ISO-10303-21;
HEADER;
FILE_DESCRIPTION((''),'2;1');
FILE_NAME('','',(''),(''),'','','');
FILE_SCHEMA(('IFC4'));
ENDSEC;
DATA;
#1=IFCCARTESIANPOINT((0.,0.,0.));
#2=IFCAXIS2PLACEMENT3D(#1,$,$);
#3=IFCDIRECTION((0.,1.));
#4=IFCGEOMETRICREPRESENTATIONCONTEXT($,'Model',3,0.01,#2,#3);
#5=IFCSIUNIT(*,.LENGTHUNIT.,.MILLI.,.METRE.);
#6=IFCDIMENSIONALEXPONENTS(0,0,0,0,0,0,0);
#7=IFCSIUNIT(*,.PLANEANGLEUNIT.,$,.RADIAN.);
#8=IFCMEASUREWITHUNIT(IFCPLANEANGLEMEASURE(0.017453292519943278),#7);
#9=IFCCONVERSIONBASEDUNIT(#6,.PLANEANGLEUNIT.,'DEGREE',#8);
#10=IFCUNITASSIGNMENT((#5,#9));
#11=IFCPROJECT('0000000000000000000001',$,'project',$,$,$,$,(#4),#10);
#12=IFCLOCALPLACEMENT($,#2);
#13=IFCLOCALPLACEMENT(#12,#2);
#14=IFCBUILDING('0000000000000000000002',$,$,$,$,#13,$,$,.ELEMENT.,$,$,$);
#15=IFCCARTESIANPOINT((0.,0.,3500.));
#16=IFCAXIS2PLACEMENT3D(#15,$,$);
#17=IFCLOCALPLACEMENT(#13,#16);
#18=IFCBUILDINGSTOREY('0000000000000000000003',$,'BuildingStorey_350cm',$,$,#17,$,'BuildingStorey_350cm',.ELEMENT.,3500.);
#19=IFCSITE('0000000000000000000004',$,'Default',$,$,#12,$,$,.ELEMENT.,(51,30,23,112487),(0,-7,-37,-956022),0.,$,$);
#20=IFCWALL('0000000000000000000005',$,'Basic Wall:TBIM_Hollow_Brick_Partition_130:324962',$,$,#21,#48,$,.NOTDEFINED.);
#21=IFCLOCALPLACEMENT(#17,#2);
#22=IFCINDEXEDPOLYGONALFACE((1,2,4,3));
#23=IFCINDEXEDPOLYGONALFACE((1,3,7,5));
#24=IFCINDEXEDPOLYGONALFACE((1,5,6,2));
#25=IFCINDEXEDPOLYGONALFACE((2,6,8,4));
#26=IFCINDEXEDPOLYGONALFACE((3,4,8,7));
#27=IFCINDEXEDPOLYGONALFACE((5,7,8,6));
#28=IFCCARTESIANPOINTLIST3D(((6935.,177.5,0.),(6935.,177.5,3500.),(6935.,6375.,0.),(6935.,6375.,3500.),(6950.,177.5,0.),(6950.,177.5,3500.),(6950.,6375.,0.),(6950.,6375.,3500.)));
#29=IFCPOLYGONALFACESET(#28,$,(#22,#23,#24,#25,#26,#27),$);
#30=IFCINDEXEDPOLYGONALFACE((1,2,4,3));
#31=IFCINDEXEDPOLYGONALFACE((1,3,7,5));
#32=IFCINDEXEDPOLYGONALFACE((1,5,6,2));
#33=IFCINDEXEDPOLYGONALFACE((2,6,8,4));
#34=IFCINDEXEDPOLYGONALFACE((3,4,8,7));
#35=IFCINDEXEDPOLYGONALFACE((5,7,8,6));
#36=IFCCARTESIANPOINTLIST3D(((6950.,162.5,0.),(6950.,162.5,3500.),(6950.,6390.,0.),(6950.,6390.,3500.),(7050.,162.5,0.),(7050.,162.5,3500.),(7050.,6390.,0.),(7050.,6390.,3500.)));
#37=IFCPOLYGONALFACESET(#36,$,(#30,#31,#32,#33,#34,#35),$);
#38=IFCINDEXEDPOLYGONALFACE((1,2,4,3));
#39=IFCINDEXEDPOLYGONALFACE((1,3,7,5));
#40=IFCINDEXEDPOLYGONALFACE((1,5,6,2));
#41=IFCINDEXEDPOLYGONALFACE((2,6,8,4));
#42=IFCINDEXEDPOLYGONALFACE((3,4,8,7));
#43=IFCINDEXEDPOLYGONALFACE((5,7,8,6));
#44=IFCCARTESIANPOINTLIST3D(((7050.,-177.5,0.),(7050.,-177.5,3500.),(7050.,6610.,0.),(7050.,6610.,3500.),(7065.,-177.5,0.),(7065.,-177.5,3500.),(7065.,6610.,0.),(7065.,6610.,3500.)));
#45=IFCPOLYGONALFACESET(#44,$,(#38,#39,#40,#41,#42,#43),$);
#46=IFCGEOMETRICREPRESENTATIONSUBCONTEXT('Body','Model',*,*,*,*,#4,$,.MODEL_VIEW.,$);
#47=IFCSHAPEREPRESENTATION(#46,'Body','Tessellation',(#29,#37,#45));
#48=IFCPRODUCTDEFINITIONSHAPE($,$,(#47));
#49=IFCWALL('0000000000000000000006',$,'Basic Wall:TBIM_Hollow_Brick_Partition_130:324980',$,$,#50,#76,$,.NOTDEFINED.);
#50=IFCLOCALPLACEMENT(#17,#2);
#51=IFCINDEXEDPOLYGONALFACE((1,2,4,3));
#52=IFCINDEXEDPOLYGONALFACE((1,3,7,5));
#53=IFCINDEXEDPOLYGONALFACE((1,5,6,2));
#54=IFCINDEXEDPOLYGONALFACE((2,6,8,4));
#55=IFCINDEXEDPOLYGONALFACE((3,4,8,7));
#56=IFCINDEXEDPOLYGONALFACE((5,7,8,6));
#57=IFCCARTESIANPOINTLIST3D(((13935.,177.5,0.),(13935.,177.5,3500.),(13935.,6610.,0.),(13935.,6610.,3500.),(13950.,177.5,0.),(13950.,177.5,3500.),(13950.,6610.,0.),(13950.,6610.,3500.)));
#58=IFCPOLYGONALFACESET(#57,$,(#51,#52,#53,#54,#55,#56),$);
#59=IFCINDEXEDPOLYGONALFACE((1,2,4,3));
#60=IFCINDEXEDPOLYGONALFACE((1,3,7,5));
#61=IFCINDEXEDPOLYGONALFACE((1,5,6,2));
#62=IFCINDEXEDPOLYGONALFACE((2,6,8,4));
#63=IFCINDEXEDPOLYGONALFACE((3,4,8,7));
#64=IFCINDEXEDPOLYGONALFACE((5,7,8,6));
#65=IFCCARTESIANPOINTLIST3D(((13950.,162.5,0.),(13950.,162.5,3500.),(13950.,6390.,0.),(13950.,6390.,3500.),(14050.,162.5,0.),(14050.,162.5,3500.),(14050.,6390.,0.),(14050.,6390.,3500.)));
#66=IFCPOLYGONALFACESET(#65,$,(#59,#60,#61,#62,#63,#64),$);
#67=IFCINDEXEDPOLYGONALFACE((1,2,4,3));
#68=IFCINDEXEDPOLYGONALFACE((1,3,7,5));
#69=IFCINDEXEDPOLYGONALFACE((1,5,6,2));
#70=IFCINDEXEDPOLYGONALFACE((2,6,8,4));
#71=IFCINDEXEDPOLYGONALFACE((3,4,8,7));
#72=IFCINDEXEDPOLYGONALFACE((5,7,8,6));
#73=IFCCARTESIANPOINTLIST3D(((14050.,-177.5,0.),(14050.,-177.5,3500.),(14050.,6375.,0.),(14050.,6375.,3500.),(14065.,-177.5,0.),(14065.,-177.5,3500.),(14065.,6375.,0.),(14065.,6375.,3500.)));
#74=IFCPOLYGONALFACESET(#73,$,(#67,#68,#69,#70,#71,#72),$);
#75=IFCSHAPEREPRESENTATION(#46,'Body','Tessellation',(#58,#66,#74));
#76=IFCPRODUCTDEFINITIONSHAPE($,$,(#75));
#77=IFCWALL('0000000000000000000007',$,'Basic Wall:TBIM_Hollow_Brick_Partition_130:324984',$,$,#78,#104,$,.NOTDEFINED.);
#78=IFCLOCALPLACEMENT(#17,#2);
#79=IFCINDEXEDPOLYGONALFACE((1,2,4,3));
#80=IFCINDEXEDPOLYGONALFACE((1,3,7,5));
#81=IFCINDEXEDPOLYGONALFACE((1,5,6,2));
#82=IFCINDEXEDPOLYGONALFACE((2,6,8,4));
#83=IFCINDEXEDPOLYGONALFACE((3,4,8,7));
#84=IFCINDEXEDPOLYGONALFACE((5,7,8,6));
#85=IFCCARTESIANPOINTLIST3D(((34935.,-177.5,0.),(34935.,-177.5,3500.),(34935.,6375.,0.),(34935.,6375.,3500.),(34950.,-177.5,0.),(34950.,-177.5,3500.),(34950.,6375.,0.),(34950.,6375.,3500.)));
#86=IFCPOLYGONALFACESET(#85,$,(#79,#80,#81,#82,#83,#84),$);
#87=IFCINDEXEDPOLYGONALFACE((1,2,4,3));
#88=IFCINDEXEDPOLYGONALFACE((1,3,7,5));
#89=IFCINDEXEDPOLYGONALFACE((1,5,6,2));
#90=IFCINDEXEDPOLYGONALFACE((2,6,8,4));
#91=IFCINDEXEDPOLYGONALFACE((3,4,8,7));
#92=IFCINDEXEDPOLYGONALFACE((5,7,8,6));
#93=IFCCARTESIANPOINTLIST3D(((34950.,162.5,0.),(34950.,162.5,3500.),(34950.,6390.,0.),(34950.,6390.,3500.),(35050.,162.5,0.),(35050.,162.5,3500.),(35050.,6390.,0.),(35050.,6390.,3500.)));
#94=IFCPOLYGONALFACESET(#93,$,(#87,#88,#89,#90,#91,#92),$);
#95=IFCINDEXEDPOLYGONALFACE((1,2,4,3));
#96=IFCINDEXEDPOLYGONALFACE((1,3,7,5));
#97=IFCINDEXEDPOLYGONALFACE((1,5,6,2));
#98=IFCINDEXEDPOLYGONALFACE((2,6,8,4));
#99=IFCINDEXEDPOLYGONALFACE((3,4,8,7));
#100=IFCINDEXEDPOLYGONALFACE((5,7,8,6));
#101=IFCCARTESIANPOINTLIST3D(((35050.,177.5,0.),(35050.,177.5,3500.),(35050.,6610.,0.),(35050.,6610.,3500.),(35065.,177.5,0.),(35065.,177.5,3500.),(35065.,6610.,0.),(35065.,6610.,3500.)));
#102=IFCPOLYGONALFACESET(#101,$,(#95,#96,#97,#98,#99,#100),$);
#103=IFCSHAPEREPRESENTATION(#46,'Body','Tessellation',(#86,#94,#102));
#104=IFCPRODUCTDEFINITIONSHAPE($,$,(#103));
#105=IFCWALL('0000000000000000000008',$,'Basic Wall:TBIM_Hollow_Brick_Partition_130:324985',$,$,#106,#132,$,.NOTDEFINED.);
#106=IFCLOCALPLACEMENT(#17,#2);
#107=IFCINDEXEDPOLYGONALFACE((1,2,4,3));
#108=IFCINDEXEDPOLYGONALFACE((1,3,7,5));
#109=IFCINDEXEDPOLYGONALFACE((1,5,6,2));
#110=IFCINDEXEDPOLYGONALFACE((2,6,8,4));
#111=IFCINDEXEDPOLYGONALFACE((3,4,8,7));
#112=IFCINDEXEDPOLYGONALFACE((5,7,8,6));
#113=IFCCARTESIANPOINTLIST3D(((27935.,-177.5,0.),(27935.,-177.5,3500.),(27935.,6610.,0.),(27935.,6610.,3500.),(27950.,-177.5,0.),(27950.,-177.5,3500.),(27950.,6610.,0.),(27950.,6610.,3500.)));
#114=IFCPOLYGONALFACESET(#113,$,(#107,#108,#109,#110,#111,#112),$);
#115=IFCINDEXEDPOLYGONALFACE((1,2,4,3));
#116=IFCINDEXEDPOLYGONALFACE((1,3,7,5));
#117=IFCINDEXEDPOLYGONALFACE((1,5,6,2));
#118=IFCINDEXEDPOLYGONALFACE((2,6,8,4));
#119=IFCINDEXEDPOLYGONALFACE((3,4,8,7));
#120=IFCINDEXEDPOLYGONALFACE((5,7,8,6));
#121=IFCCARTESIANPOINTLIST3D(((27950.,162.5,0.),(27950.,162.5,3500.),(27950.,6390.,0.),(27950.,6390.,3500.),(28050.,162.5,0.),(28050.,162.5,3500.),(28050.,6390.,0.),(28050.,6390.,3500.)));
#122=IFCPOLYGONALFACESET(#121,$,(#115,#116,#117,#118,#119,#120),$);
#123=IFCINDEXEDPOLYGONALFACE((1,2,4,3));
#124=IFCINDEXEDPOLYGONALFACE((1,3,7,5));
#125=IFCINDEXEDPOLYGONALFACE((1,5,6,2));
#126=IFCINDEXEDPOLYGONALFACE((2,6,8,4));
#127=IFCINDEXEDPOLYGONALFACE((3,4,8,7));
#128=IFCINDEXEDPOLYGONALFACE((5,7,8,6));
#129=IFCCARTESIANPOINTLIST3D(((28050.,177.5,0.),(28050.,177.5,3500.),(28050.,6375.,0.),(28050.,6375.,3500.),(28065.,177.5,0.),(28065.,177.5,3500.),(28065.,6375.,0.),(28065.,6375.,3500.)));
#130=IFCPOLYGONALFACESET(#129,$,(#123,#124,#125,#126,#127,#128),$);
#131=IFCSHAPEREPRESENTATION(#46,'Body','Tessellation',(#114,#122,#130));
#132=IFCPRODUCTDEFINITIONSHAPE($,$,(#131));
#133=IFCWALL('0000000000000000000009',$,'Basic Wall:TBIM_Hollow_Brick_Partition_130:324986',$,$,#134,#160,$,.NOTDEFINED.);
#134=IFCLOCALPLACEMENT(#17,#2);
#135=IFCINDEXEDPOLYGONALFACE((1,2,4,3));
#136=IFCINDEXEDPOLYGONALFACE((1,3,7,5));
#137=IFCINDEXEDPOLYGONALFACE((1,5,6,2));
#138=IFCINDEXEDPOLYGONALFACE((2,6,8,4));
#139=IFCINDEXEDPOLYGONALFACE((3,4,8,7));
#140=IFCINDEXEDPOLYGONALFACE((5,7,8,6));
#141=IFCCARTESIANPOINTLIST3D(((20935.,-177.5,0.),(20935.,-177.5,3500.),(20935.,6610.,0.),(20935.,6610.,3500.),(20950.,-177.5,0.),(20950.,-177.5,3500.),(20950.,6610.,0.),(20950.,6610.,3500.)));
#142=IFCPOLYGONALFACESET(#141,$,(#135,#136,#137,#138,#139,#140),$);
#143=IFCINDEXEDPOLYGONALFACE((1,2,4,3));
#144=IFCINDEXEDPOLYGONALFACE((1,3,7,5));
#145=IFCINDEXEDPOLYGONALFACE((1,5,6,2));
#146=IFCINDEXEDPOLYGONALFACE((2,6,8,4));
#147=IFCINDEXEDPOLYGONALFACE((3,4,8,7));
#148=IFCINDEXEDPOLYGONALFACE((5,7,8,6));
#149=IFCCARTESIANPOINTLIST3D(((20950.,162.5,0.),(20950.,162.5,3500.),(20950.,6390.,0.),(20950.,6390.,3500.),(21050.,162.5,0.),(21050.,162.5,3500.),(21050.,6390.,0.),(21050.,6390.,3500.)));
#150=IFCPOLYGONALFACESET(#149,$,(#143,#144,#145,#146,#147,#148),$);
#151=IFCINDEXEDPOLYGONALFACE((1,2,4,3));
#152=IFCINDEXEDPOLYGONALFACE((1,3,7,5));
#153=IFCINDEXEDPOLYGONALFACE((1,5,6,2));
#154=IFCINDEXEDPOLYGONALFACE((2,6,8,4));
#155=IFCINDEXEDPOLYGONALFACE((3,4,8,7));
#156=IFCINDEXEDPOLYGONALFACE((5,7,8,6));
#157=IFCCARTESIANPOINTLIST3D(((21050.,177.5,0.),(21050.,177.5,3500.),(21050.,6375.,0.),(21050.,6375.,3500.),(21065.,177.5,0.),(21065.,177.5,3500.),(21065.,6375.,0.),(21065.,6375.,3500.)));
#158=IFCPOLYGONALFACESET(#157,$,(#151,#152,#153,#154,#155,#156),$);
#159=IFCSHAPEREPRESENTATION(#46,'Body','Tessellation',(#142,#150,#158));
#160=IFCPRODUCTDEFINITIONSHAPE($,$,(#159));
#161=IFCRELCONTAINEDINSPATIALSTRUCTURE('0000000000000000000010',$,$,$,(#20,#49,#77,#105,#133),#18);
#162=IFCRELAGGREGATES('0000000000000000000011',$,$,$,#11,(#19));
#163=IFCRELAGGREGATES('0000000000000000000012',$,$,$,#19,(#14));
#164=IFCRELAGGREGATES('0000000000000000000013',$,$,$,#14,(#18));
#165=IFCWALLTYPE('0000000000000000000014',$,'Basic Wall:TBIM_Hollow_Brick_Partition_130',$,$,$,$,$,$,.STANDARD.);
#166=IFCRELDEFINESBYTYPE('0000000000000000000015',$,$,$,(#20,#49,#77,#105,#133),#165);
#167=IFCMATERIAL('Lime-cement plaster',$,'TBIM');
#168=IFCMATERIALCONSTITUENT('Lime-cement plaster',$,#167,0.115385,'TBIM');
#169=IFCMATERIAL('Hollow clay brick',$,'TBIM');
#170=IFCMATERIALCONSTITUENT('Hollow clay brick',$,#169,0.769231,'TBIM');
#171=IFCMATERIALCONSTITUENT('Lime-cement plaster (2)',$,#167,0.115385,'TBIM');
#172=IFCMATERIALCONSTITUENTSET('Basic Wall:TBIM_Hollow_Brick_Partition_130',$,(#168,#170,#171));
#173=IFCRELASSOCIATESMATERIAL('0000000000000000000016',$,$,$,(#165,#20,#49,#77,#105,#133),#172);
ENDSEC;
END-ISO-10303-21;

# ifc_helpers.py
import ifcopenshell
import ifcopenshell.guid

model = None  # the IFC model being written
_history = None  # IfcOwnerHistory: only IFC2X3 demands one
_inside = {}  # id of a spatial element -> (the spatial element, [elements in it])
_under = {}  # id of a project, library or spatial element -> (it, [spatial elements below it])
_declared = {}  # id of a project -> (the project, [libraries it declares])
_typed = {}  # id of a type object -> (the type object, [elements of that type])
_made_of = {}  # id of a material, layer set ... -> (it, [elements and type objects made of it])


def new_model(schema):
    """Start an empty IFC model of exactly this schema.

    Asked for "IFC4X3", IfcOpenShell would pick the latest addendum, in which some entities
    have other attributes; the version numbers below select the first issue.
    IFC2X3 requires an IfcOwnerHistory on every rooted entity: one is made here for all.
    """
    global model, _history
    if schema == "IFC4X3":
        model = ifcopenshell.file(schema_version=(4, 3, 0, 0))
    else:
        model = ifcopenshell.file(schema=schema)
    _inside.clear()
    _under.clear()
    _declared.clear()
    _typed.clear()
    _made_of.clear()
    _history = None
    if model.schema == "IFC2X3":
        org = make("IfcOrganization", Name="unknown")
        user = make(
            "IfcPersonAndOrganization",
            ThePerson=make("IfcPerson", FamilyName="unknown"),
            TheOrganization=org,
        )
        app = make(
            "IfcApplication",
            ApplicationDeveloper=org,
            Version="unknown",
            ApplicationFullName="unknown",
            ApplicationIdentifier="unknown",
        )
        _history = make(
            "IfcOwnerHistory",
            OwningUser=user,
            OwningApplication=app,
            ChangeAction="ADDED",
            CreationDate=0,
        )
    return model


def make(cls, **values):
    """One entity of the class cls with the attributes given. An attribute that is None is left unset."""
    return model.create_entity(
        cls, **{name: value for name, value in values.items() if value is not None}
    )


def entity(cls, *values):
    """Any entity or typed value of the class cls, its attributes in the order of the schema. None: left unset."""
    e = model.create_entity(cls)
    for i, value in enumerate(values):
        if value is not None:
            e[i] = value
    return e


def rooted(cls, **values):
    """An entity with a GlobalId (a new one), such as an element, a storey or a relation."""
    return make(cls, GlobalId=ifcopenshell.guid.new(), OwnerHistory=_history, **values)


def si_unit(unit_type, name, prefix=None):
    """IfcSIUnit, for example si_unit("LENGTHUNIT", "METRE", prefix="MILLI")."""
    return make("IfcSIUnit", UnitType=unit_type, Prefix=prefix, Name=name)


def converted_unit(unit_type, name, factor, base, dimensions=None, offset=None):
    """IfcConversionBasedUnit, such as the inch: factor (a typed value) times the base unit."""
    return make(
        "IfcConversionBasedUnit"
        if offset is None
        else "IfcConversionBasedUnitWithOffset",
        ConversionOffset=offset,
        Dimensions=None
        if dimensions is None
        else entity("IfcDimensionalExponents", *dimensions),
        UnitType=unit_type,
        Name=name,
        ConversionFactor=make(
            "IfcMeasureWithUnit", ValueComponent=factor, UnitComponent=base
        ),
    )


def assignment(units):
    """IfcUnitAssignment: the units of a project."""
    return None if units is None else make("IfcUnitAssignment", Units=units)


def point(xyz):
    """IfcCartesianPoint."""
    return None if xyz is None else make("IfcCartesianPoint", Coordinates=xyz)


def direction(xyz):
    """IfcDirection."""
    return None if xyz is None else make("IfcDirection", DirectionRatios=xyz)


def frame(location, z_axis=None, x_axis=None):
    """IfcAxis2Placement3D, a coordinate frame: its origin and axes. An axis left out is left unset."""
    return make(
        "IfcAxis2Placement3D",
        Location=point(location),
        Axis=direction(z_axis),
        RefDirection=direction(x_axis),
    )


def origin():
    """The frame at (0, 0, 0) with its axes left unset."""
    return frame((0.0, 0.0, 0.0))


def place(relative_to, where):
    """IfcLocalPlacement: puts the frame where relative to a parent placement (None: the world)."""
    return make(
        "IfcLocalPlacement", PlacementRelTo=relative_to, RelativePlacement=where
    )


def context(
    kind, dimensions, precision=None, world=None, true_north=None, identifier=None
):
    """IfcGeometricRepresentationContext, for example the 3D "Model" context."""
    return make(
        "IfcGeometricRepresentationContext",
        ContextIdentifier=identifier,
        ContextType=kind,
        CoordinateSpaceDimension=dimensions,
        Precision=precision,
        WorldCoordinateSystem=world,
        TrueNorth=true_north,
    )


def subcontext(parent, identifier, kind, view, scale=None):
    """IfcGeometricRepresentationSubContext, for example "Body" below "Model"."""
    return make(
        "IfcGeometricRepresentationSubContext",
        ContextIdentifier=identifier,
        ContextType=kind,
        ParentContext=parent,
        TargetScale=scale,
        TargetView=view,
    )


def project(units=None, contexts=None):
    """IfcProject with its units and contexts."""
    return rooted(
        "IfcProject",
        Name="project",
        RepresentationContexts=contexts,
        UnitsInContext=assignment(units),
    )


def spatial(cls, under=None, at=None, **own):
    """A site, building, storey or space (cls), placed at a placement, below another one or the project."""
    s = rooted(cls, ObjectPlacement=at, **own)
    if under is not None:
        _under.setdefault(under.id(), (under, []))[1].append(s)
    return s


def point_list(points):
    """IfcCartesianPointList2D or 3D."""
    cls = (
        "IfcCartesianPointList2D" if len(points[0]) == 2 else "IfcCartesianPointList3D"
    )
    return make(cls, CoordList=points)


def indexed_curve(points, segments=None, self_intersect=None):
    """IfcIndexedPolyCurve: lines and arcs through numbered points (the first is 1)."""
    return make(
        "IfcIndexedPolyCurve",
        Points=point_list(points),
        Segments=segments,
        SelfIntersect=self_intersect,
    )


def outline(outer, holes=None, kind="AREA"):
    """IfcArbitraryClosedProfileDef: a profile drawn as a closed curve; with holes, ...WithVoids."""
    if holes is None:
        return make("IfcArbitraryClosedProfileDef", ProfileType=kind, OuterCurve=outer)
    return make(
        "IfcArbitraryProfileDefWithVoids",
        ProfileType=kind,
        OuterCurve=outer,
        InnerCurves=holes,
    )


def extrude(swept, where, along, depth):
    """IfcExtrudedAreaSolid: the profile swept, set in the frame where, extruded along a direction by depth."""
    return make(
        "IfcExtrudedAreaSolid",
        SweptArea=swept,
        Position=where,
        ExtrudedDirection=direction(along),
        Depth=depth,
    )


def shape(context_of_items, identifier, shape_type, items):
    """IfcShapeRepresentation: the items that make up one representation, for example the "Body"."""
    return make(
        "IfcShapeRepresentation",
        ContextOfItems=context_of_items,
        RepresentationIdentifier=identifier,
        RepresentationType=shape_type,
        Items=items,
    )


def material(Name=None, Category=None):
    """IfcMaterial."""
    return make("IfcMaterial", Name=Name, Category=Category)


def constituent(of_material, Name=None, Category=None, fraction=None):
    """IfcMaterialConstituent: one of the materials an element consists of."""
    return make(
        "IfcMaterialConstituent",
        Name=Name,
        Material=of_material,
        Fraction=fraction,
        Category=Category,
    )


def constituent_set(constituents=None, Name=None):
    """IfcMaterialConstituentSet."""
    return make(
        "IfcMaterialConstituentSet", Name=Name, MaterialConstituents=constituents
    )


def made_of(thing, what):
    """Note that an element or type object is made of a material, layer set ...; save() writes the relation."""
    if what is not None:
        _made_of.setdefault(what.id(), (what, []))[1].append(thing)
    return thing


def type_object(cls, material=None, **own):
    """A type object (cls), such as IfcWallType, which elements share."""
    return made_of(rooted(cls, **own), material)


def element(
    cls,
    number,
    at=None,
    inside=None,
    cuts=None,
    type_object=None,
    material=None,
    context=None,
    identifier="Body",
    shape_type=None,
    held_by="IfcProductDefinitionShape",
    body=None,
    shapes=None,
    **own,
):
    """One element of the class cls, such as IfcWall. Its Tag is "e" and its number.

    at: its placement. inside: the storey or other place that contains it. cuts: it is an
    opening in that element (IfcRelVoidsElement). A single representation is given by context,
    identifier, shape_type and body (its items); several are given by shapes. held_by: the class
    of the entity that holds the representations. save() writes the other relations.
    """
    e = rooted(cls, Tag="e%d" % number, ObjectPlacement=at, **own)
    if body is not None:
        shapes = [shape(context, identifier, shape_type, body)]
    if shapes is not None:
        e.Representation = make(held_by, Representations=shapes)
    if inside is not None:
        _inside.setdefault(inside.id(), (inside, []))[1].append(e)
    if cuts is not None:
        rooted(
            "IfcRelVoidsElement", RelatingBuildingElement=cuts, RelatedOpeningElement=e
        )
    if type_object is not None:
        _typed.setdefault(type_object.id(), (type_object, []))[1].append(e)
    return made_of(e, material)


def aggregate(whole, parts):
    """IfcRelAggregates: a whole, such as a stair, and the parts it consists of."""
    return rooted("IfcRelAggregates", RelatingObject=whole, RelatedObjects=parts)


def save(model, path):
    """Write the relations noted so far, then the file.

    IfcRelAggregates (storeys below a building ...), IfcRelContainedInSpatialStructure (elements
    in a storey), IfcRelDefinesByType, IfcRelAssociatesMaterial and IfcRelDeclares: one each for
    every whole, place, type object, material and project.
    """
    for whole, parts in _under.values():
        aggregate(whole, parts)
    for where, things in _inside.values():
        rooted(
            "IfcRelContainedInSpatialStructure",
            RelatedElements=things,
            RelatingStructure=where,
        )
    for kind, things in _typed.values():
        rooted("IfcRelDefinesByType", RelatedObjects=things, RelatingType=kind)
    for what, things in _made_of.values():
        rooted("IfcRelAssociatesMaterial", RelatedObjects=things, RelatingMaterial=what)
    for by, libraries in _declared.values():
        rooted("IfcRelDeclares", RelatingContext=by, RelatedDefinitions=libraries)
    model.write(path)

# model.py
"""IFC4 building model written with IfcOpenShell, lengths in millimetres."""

from ifc_helpers import new_model, entity, si_unit, converted_unit, direction, frame, origin, place, context, subcontext, project, spatial, indexed_curve, outline, extrude, material, constituent, constituent_set, type_object, element, save


model = new_model("IFC4")

# Units and contexts
model_context = context("Model", 3, precision=0.01, world=origin(), true_north=direction((0.0, 1.0)))
body_context = subcontext(model_context, "Body", "Model", "MODEL_VIEW")
ifc_project = project(units=[si_unit("LENGTHUNIT", "METRE", prefix="MILLI"), converted_unit("PLANEANGLEUNIT", "DEGREE", entity("IfcPlaneAngleMeasure", 0.017453292519943278), si_unit("PLANEANGLEUNIT", "RADIAN"), dimensions=[0, 0, 0, 0, 0, 0, 0])], contexts=[model_context])

# Site, building, storey
site_placement = place(None, origin())
site = spatial("IfcSite", under=ifc_project, at=site_placement, Name="Default", CompositionType="ELEMENT", RefLatitude=(51, 30, 23, 112487), RefLongitude=(0, -7, -37, -956022), RefElevation=0.0)
building_placement = place(site_placement, origin())
building = spatial("IfcBuilding", under=site, at=building_placement, CompositionType="ELEMENT")
storey_placement = place(building_placement, frame((0.0, 0.0, 3500.0)))
storey = spatial("IfcBuildingStorey", under=building, at=storey_placement, Name="BuildingStorey_350cm", LongName="BuildingStorey_350cm", CompositionType="ELEMENT", Elevation=3500.0)

# Shared definitions
ifc_material_1 = material(Name="Lime-cement plaster", Category="TBIM")

# Walls
ifc_constituent_1 = constituent(ifc_material_1, Name="Lime-cement plaster", Category="TBIM", fraction=0.115385)
ifc_material_2 = material(Name="Hollow clay brick", Category="TBIM")
ifc_constituent_2 = constituent(ifc_material_2, Name="Hollow clay brick", Category="TBIM", fraction=0.769231)
ifc_constituent_3 = constituent(ifc_material_1, Name="Lime-cement plaster (2)", Category="TBIM", fraction=0.115385)
ifc_constituent_set_1 = constituent_set(constituents=[ifc_constituent_1, ifc_constituent_2, ifc_constituent_3], Name="Basic Wall:TBIM_Hollow_Brick_Partition_130")
wall_type_1 = type_object("IfcWallType", Name="Basic Wall:TBIM_Hollow_Brick_Partition_130", PredefinedType="STANDARD", material=ifc_constituent_set_1)
wall_1_placement = place(storey_placement, frame((7000.0, 177.5, 0.0), z_axis=(0.0, 0.0, 1.0), x_axis=(0.0, 1.0, 0.0)))
element("IfcWall", 1, at=wall_1_placement, inside=storey, type_object=wall_type_1, material=ifc_constituent_set_1, Name="Basic Wall:TBIM_Hollow_Brick_Partition_130:324962", PredefinedType="NOTDEFINED", context=body_context, shape_type="SweptSolid", body=[
    extrude(outline(indexed_curve([(-7.5, -3098.8), (7.5, -3098.8), (7.5, 3098.8), (-7.5, 3098.8), (-7.5, -3098.8)], self_intersect=False)), frame((3098.8, 57.5, 0.0), z_axis=(0.0, 0.0, 1.0), x_axis=(0.0, -1.0, 0.0)), (0.0, 0.0, 1.0), 3500.0),
    extrude(outline(indexed_curve([(-3113.8, -50.0), (3113.8, -50.0), (3113.8, 50.0), (-3113.8, 50.0), (-3113.8, -50.0)], self_intersect=False)), frame((3098.8, 0.0, 0.0)), (0.0, 0.0, 1.0), 3500.0),
    extrude(outline(indexed_curve([(-7.5, -3393.8), (7.5, -3393.8), (7.5, 3393.7), (-7.5, 3393.7), (-7.5, -3393.8)], self_intersect=False)), frame((3038.7, -57.5, 0.0), z_axis=(0.0, 0.0, 1.0), x_axis=(0.0, 1.0, 0.0)), (0.0, 0.0, 1.0), 3500.0),
])
wall_2_placement = place(storey_placement, frame((14000.0, 177.5, 0.0), z_axis=(0.0, 0.0, 1.0), x_axis=(0.0, 1.0, 0.0)))
element("IfcWall", 2, at=wall_2_placement, inside=storey, type_object=wall_type_1, material=ifc_constituent_set_1, Name="Basic Wall:TBIM_Hollow_Brick_Partition_130:324980", PredefinedType="NOTDEFINED", context=body_context, shape_type="SweptSolid", body=[
    extrude(outline(indexed_curve([(-7.5, -3216.2), (7.5, -3216.2), (7.5, 3216.2), (-7.5, 3216.2), (-7.5, -3216.2)], self_intersect=False)), frame((3216.2, 57.5, 0.0), z_axis=(0.0, 0.0, 1.0), x_axis=(0.0, -1.0, 0.0)), (0.0, 0.0, 1.0), 3500.0),
    extrude(outline(indexed_curve([(-3113.8, -50.0), (3113.8, -50.0), (3113.8, 50.0), (-3113.8, 50.0), (-3113.8, -50.0)], self_intersect=False)), frame((3098.8, 0.0, 0.0)), (0.0, 0.0, 1.0), 3500.0),
    extrude(outline(indexed_curve([(-7.5, -3276.2), (7.5, -3276.2), (7.5, 3276.2), (-7.5, 3276.2), (-7.5, -3276.2)], self_intersect=False)), frame((2921.3, -57.5, 0.0), z_axis=(0.0, 0.0, 1.0), x_axis=(0.0, 1.0, 0.0)), (0.0, 0.0, 1.0), 3500.0),
])
wall_3_placement = place(storey_placement, frame((35000.0, 177.5, 0.0), z_axis=(0.0, 0.0, 1.0), x_axis=(0.0, 1.0, 0.0)))
element("IfcWall", 3, at=wall_3_placement, inside=storey, type_object=wall_type_1, material=ifc_constituent_set_1, Name="Basic Wall:TBIM_Hollow_Brick_Partition_130:324984", PredefinedType="NOTDEFINED", context=body_context, shape_type="SweptSolid", body=[
    extrude(outline(indexed_curve([(-7.5, -3276.2), (7.5, -3276.2), (7.5, 3276.2), (-7.5, 3276.2), (-7.5, -3276.2)], self_intersect=False)), frame((2921.3, 57.5, 0.0), z_axis=(0.0, 0.0, 1.0), x_axis=(0.0, -1.0, 0.0)), (0.0, 0.0, 1.0), 3500.0),
    extrude(outline(indexed_curve([(-3113.8, -50.0), (3113.8, -50.0), (3113.8, 50.0), (-3113.8, 50.0), (-3113.8, -50.0)], self_intersect=False)), frame((3098.8, 0.0, 0.0)), (0.0, 0.0, 1.0), 3500.0),
    extrude(outline(indexed_curve([(-7.5, -3216.2), (7.5, -3216.2), (7.5, 3216.3), (-7.5, 3216.2), (-7.5, -3216.2)], self_intersect=False)), frame((3216.3, -57.5, 0.0), z_axis=(0.0, 0.0, 1.0), x_axis=(0.0, 1.0, 0.0)), (0.0, 0.0, 1.0), 3500.0),
])
for number, where, z_axis, x_axis, name in (
    (4, (28000.0, 177.5, 0.0), (0.0, 0.0, 1.0), (0.0, 1.0, 0.0), "Basic Wall:TBIM_Hollow_Brick_Partition_130:324985"),
    (5, (21000.0, 177.5, 0.0), (0.0, 0.0, 1.0), (0.0, 1.0, 0.0), "Basic Wall:TBIM_Hollow_Brick_Partition_130:324986"),
):
    element("IfcWall", number, at=place(storey_placement, frame(where, z_axis=z_axis, x_axis=x_axis)), inside=storey, type_object=wall_type_1, material=ifc_constituent_set_1, Name=name, PredefinedType="NOTDEFINED", context=body_context, shape_type="SweptSolid", body=[
        extrude(outline(indexed_curve([(-7.5, -3393.7), (7.5, -3393.7), (7.5, 3393.7), (-7.5, 3393.7), (-7.5, -3393.7)], self_intersect=False)), frame((3038.8, 57.5, 0.0), z_axis=(0.0, 0.0, 1.0), x_axis=(0.0, -1.0, 0.0)), (0.0, 0.0, 1.0), 3500.0),
        extrude(outline(indexed_curve([(-3113.8, -50.0), (3113.8, -50.0), (3113.8, 50.0), (-3113.8, 50.0), (-3113.8, -50.0)], self_intersect=False)), frame((3098.8, 0.0, 0.0)), (0.0, 0.0, 1.0), 3500.0),
        extrude(outline(indexed_curve([(-7.5, -3098.7), (7.5, -3098.7), (7.5, 3098.8), (-7.5, 3098.8), (-7.5, -3098.7)], self_intersect=False)), frame((3098.8, -57.5, 0.0), z_axis=(0.0, 0.0, 1.0), x_axis=(0.0, 1.0, 0.0)), (0.0, 0.0, 1.0), 3500.0),
    ])

save(model, "model.ifc")
